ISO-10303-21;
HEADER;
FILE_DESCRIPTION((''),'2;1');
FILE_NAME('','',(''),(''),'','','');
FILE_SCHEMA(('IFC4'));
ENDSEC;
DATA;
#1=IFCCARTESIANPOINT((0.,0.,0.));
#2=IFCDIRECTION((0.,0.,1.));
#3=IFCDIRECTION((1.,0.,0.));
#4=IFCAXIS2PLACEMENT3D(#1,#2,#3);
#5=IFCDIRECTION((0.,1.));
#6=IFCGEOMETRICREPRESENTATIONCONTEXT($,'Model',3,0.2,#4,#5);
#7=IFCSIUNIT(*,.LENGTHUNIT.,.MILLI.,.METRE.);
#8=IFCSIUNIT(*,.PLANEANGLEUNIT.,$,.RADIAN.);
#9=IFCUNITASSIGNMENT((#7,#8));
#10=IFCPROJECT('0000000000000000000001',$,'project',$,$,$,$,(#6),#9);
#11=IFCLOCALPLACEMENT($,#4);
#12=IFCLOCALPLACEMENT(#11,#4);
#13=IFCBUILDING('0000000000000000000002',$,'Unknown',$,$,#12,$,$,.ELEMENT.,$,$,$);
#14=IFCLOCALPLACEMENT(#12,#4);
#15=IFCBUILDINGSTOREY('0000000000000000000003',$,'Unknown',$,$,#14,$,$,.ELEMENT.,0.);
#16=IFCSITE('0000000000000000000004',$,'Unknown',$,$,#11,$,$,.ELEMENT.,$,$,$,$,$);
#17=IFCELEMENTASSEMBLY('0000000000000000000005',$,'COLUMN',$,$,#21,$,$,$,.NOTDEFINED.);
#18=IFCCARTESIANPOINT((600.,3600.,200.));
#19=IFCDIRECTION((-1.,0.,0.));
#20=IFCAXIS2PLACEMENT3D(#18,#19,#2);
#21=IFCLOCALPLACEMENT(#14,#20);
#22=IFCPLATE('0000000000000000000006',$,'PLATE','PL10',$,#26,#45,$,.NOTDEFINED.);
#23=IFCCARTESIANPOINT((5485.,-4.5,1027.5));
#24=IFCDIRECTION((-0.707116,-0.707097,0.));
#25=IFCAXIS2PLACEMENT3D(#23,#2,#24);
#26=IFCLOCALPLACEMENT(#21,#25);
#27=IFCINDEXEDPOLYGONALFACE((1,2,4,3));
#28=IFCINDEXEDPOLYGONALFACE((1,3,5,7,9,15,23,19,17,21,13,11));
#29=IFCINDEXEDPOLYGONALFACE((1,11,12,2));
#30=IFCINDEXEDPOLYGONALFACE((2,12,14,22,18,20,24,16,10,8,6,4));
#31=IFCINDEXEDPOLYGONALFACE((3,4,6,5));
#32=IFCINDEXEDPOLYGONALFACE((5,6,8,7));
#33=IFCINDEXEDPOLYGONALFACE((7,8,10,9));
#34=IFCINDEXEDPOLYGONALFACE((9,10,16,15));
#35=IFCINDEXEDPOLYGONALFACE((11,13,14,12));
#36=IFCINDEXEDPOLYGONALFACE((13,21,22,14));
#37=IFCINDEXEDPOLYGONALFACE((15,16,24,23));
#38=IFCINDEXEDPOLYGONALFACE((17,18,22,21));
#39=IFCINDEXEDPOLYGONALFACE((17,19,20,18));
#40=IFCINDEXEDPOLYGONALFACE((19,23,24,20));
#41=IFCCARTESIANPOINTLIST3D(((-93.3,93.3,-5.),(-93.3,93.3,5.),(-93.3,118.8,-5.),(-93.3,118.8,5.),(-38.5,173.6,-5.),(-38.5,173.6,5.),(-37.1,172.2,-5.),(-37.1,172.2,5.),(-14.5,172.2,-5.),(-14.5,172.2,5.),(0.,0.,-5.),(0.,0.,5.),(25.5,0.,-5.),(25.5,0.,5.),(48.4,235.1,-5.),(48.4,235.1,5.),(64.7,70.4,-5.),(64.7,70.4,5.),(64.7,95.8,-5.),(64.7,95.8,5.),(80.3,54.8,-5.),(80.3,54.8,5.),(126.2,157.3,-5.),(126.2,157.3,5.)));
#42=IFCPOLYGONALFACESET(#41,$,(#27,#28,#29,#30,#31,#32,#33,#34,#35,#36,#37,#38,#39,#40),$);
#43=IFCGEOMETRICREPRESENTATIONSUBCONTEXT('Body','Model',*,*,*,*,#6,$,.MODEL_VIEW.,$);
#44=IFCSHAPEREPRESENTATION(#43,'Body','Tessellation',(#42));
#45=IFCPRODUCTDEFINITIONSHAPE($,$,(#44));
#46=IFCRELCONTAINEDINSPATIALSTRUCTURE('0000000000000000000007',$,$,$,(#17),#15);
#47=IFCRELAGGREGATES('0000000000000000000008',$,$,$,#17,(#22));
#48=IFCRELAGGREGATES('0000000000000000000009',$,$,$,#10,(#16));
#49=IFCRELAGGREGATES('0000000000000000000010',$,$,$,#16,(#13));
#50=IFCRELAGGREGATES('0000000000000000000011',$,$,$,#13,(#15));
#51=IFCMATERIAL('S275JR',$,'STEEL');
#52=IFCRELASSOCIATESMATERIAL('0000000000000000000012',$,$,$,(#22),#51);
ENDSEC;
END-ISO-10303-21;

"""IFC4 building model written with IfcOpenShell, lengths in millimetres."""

from ifc_helpers import new_model, si_unit, direction, frame, origin_with_axes, place, context, subcontext, project, spatial, line, indexed_curve, outline, extrude, material, element, aggregate, save


model = new_model("IFC4")

# Units and contexts
model_context = context("Model", 3, precision=0.2, world=origin_with_axes(), true_north=direction((0.0, 1.0)))
body_context = subcontext(model_context, "Body", "Model", "MODEL_VIEW")
ifc_project = project(units=[si_unit("LENGTHUNIT", "METRE", prefix="MILLI"), si_unit("PLANEANGLEUNIT", "RADIAN")], contexts=[model_context])

# Site, building, storey
site_placement = place(None, origin_with_axes())
site = spatial("IfcSite", under=ifc_project, at=site_placement, Name="Unknown", CompositionType="ELEMENT")
building_placement = place(site_placement, origin_with_axes())
building = spatial("IfcBuilding", under=site, at=building_placement, Name="Unknown", CompositionType="ELEMENT")
storey_placement = place(building_placement, origin_with_axes())
storey = spatial("IfcBuildingStorey", under=building, at=storey_placement, Name="Unknown", CompositionType="ELEMENT", Elevation=0.0)

# Shared definitions
ifc_material_1 = material(Name="S275JR", Category="STEEL")

# Element assembly, plate
assembly_1_placement = place(storey_placement, frame((600.0, 3600.0, 200.0), z_axis=(-1.0, 0.0, 0.0), x_axis=(0.0, 0.0, 1.0)))
assembly_1 = element("IfcElementAssembly", 1, at=assembly_1_placement, inside=storey, Name="COLUMN", PredefinedType="NOTDEFINED")
plate_1_placement = place(assembly_1_placement, frame((5485.0, -4.5, 1027.5), z_axis=(0.0, 0.0, 1.0), x_axis=(-0.707116, -0.707097, 0.0)))
plate_1 = element("IfcPlate", 2, at=plate_1_placement, material=ifc_material_1, Name="PLATE", Description="PL10", PredefinedType="NOTDEFINED", context=body_context, shape_type="SolidModel", body=[
    extrude(outline(indexed_curve([(0.0, 0.0), (25.5, 0.0), (80.3, 54.8), (64.7, 70.4), (64.7, 95.8), (126.2, 157.3), (48.4, 235.1), (-14.5, 172.2), (-37.1, 172.2), (-38.5, 173.6), (-93.3, 118.8), (-93.3, 93.3)], segments=[line(1, 2, 3, 4, 5, 6, 7, 8, 9, 10, 11, 12, 1)])), frame((0.0, 0.0, 5.0), z_axis=(0.0, 0.0, 1.0), x_axis=(1.0, 0.0, 0.0)), (0.0, -0.000002, -1.0), 10.0),
])

aggregate(assembly_1, [plate_1])

save(model, "model.ifc")
